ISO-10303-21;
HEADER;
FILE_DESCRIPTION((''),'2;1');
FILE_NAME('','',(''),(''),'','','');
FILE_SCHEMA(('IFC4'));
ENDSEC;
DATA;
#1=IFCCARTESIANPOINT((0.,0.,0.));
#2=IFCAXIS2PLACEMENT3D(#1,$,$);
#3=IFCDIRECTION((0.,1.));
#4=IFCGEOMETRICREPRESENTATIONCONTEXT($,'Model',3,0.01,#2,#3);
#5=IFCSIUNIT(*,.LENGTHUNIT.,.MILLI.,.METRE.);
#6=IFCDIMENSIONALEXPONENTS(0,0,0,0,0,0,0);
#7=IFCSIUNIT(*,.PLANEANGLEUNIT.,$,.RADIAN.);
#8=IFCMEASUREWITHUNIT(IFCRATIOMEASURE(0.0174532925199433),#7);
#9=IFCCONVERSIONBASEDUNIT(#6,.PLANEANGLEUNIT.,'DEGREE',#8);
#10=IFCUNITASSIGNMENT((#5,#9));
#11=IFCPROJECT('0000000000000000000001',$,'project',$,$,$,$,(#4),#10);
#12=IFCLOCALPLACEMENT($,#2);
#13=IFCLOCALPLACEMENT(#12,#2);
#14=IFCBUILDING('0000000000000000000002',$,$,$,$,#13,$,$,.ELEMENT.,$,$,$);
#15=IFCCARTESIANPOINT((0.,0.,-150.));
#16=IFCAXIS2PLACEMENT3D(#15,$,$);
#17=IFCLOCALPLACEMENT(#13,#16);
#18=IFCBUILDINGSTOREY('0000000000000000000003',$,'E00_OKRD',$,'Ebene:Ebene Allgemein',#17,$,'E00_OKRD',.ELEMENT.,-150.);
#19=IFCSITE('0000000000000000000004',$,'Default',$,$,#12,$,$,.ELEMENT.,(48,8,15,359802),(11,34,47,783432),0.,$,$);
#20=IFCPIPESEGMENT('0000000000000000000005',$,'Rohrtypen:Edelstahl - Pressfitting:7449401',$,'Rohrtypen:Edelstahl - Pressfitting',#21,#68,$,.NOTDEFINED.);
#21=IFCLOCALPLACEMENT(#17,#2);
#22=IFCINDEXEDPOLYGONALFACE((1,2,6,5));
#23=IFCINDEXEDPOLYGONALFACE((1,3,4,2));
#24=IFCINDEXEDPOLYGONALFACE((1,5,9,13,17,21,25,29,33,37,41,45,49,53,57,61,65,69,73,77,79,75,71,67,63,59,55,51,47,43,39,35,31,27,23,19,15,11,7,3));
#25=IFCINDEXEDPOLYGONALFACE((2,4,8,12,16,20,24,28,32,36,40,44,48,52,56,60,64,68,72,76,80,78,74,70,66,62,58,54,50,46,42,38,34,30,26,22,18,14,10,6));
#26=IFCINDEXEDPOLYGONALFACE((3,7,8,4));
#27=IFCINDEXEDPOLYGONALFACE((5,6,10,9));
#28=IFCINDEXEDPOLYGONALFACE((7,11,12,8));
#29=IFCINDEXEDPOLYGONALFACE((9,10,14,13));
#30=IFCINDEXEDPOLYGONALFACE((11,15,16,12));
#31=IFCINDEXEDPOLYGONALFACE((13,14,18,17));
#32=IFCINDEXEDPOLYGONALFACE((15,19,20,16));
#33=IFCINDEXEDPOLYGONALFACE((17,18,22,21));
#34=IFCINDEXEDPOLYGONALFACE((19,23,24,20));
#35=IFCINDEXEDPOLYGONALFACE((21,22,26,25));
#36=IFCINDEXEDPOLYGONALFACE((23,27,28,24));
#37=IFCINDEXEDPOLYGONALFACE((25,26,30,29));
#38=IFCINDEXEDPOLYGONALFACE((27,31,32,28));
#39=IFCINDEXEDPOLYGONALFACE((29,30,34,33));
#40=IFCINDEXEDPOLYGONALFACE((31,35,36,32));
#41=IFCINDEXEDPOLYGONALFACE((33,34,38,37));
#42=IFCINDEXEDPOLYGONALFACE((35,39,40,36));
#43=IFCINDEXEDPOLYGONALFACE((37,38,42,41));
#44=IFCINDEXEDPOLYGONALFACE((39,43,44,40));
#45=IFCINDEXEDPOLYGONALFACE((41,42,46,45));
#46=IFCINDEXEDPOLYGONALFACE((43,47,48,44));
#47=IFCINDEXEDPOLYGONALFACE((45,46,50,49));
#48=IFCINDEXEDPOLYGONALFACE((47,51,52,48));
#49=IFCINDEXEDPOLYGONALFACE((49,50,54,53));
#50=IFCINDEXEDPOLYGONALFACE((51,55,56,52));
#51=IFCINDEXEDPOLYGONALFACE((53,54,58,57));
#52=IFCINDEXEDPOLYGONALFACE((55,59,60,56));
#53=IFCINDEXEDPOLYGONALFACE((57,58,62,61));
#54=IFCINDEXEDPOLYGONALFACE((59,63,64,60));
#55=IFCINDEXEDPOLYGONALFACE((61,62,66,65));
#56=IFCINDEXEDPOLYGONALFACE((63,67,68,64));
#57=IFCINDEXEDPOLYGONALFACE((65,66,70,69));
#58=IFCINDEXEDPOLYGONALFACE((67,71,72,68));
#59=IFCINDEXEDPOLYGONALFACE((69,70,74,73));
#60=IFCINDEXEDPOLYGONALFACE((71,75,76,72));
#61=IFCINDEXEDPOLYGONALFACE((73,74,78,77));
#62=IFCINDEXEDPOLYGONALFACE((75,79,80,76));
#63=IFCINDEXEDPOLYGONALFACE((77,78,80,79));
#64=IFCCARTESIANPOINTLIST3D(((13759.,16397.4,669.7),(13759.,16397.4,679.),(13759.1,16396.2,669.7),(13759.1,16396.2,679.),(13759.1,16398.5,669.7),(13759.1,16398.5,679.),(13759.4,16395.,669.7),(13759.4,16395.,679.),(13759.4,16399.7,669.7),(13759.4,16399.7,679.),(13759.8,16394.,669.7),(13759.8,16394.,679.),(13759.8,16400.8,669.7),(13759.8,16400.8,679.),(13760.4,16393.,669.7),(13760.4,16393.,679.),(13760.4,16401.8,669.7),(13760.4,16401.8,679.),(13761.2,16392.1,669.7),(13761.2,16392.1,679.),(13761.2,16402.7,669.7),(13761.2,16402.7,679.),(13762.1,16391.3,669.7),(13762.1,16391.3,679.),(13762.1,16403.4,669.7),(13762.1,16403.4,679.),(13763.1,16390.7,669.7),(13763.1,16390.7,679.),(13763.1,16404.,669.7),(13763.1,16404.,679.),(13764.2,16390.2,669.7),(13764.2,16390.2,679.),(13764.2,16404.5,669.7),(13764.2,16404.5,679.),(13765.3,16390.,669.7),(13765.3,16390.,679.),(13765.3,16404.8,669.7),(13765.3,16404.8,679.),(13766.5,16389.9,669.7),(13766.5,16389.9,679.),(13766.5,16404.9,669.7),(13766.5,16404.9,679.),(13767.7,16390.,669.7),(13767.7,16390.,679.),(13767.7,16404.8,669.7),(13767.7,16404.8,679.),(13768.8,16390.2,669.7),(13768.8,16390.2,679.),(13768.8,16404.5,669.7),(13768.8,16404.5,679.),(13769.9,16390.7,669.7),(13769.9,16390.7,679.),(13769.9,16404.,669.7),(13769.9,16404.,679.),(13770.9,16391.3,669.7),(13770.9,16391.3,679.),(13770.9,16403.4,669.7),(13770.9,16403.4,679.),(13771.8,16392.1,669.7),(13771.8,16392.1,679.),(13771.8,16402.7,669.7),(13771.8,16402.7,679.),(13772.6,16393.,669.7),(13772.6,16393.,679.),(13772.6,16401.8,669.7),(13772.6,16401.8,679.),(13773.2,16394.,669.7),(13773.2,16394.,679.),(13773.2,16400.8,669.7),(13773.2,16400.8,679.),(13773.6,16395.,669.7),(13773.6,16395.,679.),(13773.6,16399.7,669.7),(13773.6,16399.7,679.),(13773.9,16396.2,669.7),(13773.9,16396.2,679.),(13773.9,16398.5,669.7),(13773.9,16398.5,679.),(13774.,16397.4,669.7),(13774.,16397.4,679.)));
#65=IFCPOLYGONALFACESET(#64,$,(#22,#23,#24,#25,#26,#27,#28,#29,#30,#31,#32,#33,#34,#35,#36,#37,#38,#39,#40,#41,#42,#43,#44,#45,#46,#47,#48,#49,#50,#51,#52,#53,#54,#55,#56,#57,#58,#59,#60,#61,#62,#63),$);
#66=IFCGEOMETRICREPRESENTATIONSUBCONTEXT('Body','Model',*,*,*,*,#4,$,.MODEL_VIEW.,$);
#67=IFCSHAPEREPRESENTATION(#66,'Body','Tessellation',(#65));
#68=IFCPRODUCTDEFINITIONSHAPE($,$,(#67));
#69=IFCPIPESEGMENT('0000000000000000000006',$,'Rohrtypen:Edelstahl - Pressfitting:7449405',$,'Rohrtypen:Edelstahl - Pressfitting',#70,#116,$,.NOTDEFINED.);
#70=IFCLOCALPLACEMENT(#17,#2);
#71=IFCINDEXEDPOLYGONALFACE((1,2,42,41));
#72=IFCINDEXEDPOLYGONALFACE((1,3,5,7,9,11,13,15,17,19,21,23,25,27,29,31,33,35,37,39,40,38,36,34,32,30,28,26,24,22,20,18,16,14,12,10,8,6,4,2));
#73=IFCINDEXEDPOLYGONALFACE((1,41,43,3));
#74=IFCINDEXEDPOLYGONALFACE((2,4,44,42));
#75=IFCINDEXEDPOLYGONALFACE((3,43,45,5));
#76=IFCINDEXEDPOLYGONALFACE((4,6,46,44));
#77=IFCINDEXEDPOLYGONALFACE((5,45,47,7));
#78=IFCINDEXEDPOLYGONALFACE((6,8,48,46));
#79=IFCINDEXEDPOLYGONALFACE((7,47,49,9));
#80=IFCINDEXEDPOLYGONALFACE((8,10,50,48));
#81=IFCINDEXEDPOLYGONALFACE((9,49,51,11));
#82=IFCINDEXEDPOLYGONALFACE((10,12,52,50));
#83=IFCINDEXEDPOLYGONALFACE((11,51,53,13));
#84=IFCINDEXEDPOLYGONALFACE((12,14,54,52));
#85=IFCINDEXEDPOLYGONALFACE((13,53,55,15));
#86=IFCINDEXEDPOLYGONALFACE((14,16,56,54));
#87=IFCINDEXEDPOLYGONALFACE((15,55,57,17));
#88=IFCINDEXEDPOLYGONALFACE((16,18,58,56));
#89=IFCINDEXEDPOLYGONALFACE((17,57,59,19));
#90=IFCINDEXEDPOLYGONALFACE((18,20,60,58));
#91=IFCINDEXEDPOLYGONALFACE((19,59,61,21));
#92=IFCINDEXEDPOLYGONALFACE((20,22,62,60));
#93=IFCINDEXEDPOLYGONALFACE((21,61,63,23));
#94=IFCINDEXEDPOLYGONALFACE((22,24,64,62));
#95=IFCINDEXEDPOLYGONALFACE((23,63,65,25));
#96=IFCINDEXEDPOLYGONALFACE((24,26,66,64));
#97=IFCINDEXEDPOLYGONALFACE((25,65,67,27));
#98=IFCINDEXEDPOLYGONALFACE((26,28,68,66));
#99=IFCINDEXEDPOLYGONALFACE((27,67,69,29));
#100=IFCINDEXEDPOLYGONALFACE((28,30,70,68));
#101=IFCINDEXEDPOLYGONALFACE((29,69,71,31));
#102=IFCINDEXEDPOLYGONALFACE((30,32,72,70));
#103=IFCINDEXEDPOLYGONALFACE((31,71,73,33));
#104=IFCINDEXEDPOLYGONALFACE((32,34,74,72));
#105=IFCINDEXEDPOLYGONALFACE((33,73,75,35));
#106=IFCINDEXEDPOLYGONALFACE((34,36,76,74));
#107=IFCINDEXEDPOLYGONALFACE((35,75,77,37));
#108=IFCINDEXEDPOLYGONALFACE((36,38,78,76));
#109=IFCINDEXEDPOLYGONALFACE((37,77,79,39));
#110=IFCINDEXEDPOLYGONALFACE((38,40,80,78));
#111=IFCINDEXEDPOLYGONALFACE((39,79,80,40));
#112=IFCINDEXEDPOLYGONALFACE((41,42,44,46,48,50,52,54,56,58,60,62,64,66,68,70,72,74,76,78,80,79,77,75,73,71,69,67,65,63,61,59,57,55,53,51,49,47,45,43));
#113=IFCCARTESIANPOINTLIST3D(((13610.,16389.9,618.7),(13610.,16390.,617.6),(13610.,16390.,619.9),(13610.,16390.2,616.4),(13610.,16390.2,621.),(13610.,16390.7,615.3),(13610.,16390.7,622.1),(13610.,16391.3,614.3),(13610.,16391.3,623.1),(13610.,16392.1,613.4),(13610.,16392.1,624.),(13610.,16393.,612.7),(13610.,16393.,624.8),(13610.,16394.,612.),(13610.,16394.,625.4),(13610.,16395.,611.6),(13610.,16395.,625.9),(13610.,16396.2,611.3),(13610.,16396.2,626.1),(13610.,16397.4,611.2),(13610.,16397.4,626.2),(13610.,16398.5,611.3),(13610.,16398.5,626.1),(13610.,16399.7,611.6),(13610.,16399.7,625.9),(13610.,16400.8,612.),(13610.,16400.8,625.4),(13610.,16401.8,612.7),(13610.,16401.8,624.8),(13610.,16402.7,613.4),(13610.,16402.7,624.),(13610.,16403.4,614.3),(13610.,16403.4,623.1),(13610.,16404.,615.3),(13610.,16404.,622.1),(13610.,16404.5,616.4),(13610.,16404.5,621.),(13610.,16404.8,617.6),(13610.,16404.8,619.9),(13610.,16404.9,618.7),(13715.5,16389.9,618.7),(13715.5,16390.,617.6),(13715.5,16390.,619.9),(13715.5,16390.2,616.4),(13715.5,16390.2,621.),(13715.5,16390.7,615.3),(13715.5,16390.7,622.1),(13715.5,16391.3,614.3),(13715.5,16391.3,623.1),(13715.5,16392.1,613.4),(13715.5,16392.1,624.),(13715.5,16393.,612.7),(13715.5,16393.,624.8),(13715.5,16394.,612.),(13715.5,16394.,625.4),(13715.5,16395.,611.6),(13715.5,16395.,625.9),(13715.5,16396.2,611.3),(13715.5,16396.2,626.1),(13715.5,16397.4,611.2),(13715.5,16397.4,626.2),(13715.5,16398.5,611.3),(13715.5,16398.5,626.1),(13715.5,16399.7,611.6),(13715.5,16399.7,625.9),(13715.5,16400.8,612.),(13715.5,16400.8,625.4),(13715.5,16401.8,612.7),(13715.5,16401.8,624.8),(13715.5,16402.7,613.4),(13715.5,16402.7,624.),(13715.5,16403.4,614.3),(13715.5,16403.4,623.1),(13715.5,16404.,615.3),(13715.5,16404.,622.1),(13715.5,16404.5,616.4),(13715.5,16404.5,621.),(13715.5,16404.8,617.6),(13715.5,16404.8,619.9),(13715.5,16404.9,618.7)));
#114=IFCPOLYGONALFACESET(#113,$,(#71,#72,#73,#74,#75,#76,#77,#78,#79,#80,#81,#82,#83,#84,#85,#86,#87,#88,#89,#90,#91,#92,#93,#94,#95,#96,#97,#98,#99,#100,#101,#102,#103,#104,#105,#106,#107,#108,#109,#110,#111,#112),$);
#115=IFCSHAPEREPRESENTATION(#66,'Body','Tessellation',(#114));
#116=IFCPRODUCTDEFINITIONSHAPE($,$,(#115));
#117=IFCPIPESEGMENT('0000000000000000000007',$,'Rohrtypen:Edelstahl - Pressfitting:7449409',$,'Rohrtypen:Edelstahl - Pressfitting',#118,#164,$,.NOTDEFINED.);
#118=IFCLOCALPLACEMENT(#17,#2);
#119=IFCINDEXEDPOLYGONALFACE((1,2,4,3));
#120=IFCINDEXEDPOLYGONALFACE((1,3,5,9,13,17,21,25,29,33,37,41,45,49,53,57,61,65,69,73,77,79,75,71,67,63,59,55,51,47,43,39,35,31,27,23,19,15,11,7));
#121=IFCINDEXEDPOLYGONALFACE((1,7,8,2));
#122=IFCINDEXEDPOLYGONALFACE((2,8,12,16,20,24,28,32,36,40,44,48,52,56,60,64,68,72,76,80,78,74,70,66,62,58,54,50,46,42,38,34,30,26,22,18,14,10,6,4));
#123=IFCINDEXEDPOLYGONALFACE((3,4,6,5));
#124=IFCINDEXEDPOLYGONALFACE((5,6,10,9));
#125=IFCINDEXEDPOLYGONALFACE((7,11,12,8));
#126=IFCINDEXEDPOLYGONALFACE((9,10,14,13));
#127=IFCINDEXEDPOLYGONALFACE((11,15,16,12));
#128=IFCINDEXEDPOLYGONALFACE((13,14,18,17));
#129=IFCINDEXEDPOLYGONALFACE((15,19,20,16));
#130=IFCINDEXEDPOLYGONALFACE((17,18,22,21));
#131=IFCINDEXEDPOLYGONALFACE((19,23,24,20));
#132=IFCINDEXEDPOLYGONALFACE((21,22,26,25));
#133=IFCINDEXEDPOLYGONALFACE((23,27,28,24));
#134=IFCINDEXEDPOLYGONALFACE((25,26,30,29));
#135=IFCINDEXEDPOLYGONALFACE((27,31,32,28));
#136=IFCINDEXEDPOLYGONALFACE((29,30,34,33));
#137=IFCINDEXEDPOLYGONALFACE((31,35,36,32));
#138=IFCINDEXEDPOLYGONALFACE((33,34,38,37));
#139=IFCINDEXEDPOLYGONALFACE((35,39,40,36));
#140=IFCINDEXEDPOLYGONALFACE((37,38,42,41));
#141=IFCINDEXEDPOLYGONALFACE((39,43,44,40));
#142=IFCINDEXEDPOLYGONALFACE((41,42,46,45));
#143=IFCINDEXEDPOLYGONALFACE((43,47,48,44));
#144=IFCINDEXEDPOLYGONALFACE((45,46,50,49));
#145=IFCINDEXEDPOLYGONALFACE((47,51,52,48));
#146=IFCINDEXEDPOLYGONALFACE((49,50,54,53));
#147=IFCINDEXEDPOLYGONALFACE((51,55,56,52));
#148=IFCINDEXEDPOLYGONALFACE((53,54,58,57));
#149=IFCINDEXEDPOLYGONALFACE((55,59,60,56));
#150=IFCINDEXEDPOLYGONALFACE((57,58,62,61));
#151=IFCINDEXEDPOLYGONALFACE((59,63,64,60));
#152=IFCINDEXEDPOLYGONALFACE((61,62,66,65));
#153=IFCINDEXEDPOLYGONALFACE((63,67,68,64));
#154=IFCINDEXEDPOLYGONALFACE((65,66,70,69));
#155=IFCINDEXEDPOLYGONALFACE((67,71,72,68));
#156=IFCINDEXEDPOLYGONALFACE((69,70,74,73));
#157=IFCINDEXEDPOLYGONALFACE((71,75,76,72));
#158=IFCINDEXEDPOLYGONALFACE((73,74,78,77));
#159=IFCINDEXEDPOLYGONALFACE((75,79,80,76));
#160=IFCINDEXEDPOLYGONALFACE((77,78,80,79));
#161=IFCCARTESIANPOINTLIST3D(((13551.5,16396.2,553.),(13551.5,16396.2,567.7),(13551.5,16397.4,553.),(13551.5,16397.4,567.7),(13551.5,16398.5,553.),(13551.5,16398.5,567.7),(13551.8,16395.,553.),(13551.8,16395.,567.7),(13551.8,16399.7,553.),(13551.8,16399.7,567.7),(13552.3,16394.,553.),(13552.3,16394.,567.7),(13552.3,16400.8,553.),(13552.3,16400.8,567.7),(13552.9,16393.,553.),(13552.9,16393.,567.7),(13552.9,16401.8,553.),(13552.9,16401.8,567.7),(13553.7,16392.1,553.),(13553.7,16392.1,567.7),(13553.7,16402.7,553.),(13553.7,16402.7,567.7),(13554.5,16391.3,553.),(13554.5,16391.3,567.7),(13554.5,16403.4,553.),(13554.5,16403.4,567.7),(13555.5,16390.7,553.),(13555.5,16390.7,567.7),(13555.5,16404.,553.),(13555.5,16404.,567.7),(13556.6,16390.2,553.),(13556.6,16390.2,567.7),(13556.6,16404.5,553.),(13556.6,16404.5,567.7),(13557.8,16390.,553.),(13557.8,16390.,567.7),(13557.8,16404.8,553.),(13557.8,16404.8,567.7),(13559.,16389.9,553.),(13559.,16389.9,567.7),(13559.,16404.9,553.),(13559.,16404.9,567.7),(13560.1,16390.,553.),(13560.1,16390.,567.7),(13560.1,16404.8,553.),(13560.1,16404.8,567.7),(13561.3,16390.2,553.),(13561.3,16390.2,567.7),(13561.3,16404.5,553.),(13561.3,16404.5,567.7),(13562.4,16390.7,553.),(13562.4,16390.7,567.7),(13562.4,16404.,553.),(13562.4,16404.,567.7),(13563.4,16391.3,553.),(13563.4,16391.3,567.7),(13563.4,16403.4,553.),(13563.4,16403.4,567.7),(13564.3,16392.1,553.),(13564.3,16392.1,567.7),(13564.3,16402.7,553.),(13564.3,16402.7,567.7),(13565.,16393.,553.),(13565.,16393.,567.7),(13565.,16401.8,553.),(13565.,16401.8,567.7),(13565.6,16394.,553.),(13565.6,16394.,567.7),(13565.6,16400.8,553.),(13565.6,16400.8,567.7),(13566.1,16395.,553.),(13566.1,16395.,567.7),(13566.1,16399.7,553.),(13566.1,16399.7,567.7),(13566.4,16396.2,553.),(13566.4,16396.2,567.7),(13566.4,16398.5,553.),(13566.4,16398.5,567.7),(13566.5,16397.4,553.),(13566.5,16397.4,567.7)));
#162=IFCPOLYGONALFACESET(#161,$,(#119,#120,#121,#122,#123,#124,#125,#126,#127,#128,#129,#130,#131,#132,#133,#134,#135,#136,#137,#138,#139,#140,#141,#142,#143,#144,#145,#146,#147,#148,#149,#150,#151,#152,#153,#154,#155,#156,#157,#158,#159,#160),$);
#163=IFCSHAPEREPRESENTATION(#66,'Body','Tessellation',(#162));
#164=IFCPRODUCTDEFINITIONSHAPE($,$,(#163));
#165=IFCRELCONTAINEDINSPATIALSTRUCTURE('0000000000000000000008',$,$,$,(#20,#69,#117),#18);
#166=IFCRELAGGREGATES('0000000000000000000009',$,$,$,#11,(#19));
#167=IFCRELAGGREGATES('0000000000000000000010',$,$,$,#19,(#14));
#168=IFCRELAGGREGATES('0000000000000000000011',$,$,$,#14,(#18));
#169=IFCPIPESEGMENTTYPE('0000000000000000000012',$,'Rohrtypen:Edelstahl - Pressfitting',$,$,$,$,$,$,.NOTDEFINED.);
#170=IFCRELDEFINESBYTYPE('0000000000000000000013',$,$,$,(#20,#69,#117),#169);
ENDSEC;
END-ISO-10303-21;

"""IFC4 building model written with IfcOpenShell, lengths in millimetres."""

from ifc_helpers import new_model, entity, si_unit, converted_unit, direction, frame, origin, place, context, subcontext, project, spatial, indexed_curve, outline, extrude, type_object, element, save


model = new_model("IFC4")

# Units and contexts
model_context = context("Model", 3, precision=0.01, world=origin(), true_north=direction((0.0, 1.0)))
body_context = subcontext(model_context, "Body", "Model", "MODEL_VIEW")
ifc_project = project(units=[si_unit("LENGTHUNIT", "METRE", prefix="MILLI"), converted_unit("PLANEANGLEUNIT", "DEGREE", entity("IfcRatioMeasure", 0.0174532925199433), si_unit("PLANEANGLEUNIT", "RADIAN"), dimensions=[0, 0, 0, 0, 0, 0, 0])], contexts=[model_context])

# Site, building, storey
site_placement = place(None, origin())
site = spatial("IfcSite", under=ifc_project, at=site_placement, Name="Default", CompositionType="ELEMENT", RefLatitude=(48, 8, 15, 359802), RefLongitude=(11, 34, 47, 783432), RefElevation=0.0)
building_placement = place(site_placement, origin())
building = spatial("IfcBuilding", under=site, at=building_placement, CompositionType="ELEMENT")
storey_placement = place(building_placement, frame((0.0, 0.0, -150.0)))
storey = spatial("IfcBuildingStorey", under=building, at=storey_placement, Name="E00_OKRD", ObjectType="Ebene:Ebene Allgemein", LongName="E00_OKRD", CompositionType="ELEMENT", Elevation=-150.0)

# Pipe segments
pipe_segment_type_1 = type_object("IfcPipeSegmentType", Name="Rohrtypen:Edelstahl - Pressfitting", PredefinedType="NOTDEFINED")
pipe_segment_1_placement = place(storey_placement, origin())
element("IfcPipeSegment", 1, at=pipe_segment_1_placement, inside=storey, type_object=pipe_segment_type_1, Name="Rohrtypen:Edelstahl - Pressfitting:7449401", ObjectType="Rohrtypen:Edelstahl - Pressfitting", PredefinedType="NOTDEFINED", context=body_context, shape_type="SweptSolid", body=[
    extrude(outline(indexed_curve([(7.5, 0.0), (7.4, 1.2), (7.1, 2.3), (6.7, 3.4), (6.1, 4.4), (5.3, 5.3), (4.4, 6.1), (3.4, 6.7), (2.3, 7.1), (1.2, 7.4), (0.0, 7.5), (-1.2, 7.4), (-2.3, 7.1), (-3.4, 6.7), (-4.4, 6.1), (-5.3, 5.3), (-6.1, 4.4), (-6.7, 3.4), (-7.1, 2.3), (-7.4, 1.2), (-7.5, 0.0), (-7.4, -1.2), (-7.1, -2.3), (-6.7, -3.4), (-6.1, -4.4), (-5.3, -5.3), (-4.4, -6.1), (-3.4, -6.7), (-2.3, -7.1), (-1.2, -7.4), (0.0, -7.5), (1.2, -7.4), (2.3, -7.1), (3.4, -6.7), (4.4, -6.1), (5.3, -5.3), (6.1, -4.4), (6.7, -3.4), (7.1, -2.3), (7.4, -1.2), (7.5, 0.0)], self_intersect=False)), frame((13766.5, 16397.4, 669.7)), (0.0, 0.0, 1.0), 9.3),
])
pipe_segment_2_placement = place(storey_placement, origin())
element("IfcPipeSegment", 2, at=pipe_segment_2_placement, inside=storey, type_object=pipe_segment_type_1, Name="Rohrtypen:Edelstahl - Pressfitting:7449405", ObjectType="Rohrtypen:Edelstahl - Pressfitting", PredefinedType="NOTDEFINED", context=body_context, shape_type="SweptSolid", body=[
    extrude(outline(indexed_curve([(7.5, 0.0), (7.4, 1.2), (7.1, 2.3), (6.7, 3.4), (6.1, 4.4), (5.3, 5.3), (4.4, 6.1), (3.4, 6.7), (2.3, 7.1), (1.2, 7.4), (0.0, 7.5), (-1.2, 7.4), (-2.3, 7.1), (-3.4, 6.7), (-4.4, 6.1), (-5.3, 5.3), (-6.1, 4.4), (-6.7, 3.4), (-7.1, 2.3), (-7.4, 1.2), (-7.5, 0.0), (-7.4, -1.2), (-7.1, -2.3), (-6.7, -3.4), (-6.1, -4.4), (-5.3, -5.3), (-4.4, -6.1), (-3.4, -6.7), (-2.3, -7.1), (-1.2, -7.4), (0.0, -7.5), (1.2, -7.4), (2.3, -7.1), (3.4, -6.7), (4.4, -6.1), (5.3, -5.3), (6.1, -4.4), (6.7, -3.4), (7.1, -2.3), (7.4, -1.2), (7.5, 0.0)], self_intersect=False)), frame((13610.0, 16397.4, 618.7), z_axis=(1.0, 0.0, 0.0), x_axis=(0.0, 1.0, 0.0)), (0.0, 0.0, 1.0), 105.6),
])
pipe_segment_3_placement = place(storey_placement, origin())
element("IfcPipeSegment", 3, at=pipe_segment_3_placement, inside=storey, type_object=pipe_segment_type_1, Name="Rohrtypen:Edelstahl - Pressfitting:7449409", ObjectType="Rohrtypen:Edelstahl - Pressfitting", PredefinedType="NOTDEFINED", context=body_context, shape_type="SweptSolid", body=[
    extrude(outline(indexed_curve([(7.5, 0.0), (7.4, 1.2), (7.1, 2.3), (6.7, 3.4), (6.1, 4.4), (5.3, 5.3), (4.4, 6.1), (3.4, 6.7), (2.3, 7.1), (1.2, 7.4), (0.0, 7.5), (-1.2, 7.4), (-2.3, 7.1), (-3.4, 6.7), (-4.4, 6.1), (-5.3, 5.3), (-6.1, 4.4), (-6.7, 3.4), (-7.1, 2.3), (-7.4, 1.2), (-7.5, 0.0), (-7.4, -1.2), (-7.1, -2.3), (-6.7, -3.4), (-6.1, -4.4), (-5.3, -5.3), (-4.4, -6.1), (-3.4, -6.7), (-2.3, -7.1), (-1.2, -7.4), (0.0, -7.5), (1.2, -7.4), (2.3, -7.1), (3.4, -6.7), (4.4, -6.1), (5.3, -5.3), (6.1, -4.4), (6.7, -3.4), (7.1, -2.3), (7.4, -1.2), (7.5, 0.0)], self_intersect=False)), frame((13559.0, 16397.4, 553.0)), (0.0, 0.0, 1.0), 14.7),
])

save(model, "model.ifc")
